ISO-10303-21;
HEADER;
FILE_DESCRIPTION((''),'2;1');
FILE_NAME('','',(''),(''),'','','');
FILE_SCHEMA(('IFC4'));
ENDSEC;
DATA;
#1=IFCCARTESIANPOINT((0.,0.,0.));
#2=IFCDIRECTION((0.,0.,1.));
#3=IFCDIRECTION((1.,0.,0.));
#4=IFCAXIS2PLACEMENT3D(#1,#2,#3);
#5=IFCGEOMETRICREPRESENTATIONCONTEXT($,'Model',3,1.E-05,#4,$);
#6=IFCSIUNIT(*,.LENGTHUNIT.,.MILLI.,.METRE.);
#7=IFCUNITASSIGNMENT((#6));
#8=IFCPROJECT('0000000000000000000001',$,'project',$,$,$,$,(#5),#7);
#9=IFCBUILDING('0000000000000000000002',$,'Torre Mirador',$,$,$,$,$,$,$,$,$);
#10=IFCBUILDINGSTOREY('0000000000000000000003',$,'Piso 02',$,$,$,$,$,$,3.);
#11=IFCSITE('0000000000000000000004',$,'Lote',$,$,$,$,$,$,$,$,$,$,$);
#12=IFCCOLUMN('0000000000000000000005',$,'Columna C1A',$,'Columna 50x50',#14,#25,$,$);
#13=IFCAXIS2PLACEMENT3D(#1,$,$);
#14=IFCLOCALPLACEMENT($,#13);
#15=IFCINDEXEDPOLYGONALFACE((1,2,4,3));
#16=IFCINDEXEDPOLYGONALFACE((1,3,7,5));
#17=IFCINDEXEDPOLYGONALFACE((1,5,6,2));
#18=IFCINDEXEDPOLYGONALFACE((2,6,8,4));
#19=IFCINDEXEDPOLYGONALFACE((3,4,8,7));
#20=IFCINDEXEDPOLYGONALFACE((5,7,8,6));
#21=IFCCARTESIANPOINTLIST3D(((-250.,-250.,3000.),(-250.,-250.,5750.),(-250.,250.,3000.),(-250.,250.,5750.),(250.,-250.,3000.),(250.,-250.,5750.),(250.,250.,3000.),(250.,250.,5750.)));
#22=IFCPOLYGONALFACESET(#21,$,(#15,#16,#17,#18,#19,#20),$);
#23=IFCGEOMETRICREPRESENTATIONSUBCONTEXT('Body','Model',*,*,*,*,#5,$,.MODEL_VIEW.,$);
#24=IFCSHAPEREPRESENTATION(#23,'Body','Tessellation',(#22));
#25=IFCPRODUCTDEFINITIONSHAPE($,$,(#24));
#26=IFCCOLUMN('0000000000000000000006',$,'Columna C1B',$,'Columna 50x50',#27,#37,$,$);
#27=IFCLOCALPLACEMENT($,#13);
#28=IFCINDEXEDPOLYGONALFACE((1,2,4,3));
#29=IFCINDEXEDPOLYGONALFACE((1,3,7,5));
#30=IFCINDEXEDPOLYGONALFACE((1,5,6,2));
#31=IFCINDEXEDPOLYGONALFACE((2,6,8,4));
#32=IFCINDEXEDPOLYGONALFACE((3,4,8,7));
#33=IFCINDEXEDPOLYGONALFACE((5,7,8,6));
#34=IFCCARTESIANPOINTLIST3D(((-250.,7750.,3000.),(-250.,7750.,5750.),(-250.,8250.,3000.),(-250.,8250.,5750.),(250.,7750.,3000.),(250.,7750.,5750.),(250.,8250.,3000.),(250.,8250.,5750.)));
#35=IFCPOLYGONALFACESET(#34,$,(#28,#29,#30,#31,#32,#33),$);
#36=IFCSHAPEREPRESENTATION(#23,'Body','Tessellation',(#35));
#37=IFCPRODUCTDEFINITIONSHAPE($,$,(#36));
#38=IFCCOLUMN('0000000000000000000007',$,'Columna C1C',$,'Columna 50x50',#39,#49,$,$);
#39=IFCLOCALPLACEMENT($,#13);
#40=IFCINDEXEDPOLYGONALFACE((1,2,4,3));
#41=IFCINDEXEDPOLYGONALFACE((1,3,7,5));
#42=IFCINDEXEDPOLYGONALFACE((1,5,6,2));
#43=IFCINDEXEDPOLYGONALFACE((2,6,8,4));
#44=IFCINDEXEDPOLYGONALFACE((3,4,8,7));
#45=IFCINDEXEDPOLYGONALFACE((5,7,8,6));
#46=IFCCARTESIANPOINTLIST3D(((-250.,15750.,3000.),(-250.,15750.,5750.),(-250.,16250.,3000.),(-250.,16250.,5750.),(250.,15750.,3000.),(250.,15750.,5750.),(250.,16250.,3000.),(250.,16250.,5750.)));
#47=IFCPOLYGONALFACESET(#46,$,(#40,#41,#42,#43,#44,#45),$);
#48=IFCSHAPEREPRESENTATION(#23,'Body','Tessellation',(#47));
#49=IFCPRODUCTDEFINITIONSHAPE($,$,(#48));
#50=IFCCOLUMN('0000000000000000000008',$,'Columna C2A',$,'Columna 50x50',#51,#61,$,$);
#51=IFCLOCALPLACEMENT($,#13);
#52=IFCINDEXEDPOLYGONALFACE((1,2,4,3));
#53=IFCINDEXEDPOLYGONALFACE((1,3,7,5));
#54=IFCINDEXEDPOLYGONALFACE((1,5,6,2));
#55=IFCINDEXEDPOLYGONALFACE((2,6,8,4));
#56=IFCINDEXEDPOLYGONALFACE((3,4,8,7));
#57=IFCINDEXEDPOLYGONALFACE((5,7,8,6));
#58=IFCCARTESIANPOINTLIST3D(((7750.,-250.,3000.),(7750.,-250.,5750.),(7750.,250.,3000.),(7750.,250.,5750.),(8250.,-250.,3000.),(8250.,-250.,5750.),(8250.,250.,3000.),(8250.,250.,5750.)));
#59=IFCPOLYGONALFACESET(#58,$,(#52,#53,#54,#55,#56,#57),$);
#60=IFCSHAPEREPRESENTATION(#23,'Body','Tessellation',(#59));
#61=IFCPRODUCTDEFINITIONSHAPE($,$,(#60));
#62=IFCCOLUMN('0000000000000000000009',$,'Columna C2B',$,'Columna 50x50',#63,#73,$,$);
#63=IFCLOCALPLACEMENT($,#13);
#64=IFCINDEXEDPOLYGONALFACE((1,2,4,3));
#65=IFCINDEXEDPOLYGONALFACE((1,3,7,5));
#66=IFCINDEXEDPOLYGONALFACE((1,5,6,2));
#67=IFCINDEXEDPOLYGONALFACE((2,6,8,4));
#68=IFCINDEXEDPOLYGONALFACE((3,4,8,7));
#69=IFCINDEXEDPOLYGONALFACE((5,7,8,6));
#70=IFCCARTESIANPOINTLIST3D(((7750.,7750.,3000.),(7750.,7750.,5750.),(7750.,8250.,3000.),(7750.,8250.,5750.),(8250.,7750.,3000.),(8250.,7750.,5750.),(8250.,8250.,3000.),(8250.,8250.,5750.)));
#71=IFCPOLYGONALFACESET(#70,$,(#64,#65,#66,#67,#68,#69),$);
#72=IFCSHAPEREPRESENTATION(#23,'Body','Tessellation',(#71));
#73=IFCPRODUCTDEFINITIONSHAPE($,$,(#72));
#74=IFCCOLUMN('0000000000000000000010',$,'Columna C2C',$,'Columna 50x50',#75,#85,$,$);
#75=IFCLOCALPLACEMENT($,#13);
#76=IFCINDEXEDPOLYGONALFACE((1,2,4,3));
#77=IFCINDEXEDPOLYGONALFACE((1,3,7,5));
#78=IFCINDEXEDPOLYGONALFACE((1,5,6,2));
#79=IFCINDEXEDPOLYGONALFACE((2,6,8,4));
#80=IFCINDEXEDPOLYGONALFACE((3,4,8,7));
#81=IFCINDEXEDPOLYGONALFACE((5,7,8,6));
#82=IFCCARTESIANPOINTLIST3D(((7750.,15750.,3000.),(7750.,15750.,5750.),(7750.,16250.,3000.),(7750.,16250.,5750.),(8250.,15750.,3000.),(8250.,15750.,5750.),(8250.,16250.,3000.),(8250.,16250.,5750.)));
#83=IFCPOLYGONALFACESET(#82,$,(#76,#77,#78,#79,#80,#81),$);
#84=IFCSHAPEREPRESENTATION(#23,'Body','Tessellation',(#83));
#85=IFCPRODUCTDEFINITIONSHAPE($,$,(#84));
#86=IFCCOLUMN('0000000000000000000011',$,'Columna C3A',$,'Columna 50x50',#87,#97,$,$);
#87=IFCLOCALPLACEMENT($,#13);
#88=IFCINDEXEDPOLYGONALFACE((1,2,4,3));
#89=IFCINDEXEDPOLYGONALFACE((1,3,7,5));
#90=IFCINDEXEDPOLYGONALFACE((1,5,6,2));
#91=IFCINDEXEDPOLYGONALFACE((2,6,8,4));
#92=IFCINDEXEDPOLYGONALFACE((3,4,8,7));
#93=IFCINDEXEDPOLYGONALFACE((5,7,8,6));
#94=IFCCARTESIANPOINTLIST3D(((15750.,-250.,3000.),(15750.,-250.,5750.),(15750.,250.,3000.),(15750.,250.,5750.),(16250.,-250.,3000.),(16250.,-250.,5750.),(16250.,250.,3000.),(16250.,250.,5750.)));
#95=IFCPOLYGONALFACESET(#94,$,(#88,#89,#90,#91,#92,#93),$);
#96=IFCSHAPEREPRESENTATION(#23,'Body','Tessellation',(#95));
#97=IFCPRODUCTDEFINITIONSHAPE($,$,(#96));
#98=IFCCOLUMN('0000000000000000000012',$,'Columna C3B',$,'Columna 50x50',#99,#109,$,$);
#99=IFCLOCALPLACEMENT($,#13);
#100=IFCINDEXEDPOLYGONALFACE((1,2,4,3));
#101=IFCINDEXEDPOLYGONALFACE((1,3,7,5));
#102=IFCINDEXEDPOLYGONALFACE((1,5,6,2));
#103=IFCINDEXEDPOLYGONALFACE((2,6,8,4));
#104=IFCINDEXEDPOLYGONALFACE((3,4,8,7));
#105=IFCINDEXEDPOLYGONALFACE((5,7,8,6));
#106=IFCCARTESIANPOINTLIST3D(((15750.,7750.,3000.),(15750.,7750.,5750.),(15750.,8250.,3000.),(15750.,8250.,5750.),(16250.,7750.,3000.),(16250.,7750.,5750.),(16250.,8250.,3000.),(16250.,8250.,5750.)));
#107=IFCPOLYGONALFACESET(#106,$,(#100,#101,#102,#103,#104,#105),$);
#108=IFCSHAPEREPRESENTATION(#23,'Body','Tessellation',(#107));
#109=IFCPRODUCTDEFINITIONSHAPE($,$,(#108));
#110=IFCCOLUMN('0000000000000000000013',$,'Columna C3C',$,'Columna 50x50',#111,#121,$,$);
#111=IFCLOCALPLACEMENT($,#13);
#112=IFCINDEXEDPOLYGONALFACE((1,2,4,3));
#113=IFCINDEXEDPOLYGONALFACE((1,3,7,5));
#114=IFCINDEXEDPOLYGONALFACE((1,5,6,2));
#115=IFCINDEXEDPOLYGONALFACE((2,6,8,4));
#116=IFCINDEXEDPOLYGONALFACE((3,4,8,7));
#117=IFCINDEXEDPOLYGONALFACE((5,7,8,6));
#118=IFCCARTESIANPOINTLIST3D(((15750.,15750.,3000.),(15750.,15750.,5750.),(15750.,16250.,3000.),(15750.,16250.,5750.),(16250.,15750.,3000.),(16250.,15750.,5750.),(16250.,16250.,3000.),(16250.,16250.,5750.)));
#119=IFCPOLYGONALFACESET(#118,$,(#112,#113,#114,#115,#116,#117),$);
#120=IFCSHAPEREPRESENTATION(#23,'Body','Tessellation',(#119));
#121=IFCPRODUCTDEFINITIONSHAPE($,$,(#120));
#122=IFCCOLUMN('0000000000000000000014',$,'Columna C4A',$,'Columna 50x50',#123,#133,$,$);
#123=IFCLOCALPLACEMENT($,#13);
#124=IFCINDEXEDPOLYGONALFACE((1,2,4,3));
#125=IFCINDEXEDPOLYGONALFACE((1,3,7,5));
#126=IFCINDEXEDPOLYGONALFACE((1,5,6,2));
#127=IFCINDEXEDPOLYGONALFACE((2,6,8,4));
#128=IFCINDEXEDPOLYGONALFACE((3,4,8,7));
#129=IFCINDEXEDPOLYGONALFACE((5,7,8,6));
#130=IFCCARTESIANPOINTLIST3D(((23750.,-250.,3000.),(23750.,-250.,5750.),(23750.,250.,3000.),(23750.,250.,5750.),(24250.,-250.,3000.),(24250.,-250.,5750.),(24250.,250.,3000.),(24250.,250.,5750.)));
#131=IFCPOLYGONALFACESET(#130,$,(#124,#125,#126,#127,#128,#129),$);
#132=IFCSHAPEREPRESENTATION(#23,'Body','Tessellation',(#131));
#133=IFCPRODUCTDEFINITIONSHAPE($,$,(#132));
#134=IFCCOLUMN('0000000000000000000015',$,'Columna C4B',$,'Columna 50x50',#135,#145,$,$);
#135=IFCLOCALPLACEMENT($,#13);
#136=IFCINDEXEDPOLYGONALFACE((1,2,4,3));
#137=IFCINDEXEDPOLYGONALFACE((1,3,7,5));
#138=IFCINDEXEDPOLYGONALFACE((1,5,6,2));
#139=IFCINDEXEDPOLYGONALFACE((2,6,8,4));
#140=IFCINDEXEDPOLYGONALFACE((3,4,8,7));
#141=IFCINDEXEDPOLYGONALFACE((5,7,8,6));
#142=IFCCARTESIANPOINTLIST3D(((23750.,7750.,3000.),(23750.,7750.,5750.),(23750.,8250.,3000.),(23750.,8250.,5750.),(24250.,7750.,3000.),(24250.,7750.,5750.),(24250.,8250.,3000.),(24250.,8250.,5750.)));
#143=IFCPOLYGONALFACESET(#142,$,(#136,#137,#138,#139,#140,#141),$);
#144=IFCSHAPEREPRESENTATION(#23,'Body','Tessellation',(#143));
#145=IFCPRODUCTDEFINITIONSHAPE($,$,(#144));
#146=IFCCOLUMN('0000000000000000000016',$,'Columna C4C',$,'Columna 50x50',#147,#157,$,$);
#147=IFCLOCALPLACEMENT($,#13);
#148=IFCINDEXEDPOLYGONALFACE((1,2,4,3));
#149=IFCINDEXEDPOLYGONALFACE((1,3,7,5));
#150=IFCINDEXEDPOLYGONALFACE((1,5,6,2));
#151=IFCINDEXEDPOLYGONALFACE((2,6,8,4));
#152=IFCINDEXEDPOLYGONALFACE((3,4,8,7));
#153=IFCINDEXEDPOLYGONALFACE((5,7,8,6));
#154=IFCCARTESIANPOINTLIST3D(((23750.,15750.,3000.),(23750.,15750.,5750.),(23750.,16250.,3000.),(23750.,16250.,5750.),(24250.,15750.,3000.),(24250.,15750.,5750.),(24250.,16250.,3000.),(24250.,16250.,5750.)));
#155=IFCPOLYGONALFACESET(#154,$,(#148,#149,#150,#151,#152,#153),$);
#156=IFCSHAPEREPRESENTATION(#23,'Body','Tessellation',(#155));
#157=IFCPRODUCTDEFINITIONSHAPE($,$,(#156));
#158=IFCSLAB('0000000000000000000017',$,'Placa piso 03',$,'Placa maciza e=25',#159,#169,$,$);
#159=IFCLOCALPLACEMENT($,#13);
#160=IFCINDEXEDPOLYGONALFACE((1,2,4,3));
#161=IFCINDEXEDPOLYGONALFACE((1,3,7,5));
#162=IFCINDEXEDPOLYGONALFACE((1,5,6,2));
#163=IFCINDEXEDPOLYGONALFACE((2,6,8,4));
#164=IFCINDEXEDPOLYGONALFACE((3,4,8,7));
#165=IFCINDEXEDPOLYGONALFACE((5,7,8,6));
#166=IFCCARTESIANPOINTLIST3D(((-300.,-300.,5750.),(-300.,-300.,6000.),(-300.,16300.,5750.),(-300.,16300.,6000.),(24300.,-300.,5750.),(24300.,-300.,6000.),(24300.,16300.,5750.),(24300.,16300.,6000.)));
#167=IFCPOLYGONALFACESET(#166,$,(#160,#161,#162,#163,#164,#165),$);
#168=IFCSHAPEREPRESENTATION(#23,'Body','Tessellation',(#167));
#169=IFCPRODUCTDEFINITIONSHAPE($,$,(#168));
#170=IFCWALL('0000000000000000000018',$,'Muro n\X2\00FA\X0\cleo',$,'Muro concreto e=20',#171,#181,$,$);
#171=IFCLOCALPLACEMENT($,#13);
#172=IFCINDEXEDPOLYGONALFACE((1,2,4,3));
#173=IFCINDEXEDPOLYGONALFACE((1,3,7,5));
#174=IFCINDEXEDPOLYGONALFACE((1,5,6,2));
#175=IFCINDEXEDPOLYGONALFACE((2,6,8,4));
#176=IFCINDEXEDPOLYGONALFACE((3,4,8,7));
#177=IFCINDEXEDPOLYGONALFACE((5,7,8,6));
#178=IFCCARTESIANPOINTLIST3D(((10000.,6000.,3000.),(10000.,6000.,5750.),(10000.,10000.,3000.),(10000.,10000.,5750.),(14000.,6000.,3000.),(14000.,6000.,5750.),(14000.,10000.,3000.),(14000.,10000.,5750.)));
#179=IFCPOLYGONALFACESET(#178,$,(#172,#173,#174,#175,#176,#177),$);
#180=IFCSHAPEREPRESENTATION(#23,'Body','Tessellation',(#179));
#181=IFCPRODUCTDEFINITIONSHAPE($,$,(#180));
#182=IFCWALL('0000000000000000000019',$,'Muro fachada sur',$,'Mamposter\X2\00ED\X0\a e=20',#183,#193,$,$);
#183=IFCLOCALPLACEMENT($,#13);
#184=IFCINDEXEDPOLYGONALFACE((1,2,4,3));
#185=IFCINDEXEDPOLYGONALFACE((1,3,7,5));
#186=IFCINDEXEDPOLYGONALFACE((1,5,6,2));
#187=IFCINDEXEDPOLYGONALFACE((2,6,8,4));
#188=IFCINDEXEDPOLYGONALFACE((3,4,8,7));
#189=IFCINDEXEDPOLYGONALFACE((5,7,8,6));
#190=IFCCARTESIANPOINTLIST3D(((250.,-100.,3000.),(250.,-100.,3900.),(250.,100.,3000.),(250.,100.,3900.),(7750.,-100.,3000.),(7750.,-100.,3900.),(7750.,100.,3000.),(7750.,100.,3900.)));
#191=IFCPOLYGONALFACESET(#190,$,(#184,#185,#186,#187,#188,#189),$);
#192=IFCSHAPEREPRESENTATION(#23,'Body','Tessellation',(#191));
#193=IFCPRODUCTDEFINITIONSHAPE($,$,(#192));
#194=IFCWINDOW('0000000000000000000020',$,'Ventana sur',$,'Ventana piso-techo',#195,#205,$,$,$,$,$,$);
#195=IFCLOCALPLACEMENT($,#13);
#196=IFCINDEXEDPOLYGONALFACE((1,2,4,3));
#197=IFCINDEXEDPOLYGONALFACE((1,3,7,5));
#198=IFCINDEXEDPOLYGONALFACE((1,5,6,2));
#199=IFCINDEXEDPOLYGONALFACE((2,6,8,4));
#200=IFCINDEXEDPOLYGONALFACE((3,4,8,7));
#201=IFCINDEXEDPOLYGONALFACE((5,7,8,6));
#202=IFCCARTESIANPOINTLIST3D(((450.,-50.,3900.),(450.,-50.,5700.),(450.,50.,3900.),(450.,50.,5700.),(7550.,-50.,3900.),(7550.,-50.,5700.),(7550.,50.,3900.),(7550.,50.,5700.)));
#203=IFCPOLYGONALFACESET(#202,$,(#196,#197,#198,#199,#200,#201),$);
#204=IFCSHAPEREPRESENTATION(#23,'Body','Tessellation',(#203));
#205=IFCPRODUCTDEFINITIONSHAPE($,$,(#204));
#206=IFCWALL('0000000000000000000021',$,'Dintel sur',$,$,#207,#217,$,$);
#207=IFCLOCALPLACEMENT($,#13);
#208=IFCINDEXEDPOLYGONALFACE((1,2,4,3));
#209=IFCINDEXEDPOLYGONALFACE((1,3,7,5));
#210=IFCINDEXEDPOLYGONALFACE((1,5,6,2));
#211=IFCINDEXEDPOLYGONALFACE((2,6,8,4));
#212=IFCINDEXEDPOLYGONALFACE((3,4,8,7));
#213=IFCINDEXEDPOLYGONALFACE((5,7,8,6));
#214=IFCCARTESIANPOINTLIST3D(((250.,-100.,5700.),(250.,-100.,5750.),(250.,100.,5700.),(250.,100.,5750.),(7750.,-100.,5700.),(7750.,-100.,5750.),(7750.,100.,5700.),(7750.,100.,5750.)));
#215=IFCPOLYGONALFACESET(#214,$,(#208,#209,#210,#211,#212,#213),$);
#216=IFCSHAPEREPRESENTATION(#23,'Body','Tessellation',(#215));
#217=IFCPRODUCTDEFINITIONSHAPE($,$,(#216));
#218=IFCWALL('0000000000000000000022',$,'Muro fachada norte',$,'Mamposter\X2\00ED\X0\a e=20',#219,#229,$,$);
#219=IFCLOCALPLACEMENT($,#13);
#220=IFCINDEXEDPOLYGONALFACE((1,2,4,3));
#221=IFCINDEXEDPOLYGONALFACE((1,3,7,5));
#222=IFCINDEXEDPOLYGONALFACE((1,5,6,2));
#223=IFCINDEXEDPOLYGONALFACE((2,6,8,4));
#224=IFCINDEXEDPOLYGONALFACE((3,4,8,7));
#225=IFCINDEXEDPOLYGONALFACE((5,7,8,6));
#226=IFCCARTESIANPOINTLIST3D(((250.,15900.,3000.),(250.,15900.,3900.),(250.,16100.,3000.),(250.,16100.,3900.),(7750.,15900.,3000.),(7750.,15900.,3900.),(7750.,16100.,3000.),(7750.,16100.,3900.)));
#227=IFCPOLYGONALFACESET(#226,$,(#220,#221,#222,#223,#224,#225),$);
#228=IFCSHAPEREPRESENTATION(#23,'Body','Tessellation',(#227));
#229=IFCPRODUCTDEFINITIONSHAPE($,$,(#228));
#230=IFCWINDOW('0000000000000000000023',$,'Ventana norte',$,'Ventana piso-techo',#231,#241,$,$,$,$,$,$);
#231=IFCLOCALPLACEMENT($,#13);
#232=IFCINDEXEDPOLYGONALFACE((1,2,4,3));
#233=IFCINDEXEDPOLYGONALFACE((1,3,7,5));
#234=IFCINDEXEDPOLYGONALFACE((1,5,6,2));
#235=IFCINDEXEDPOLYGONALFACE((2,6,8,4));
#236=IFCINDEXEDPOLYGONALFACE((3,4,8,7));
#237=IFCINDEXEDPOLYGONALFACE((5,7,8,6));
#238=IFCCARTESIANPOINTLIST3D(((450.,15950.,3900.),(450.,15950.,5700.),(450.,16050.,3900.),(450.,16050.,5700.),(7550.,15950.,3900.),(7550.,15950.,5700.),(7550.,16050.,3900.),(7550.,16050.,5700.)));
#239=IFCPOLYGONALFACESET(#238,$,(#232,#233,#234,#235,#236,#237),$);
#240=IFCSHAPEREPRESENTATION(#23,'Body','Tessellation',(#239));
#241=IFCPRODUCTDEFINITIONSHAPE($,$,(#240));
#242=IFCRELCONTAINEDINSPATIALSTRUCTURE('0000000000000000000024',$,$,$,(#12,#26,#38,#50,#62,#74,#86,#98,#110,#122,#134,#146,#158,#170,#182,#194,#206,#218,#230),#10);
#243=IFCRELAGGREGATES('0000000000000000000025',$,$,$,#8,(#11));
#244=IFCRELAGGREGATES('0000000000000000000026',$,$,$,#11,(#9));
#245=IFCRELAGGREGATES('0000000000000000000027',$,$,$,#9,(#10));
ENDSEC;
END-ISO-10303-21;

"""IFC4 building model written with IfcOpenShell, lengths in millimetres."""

from ifc_helpers import new_model, si_unit, frame, origin_with_axes, place, context, subcontext, project, spatial, indexed_curve, outline, extrude, element, save


model = new_model("IFC4")

# Units and contexts
model_context = context("Model", 3, precision=1e-05, world=origin_with_axes())
body_context = subcontext(model_context, "Body", "Model", "MODEL_VIEW")
ifc_project = project(units=[si_unit("LENGTHUNIT", "METRE", prefix="MILLI")], contexts=[model_context])

# Site, building, storey
site = spatial("IfcSite", under=ifc_project, Name="Lote")
building = spatial("IfcBuilding", under=site, Name="Torre Mirador")
storey = spatial("IfcBuildingStorey", under=building, Name="Piso 02", Elevation=3.0)

# Columns
for number, where, z_axis, x_axis, name in (
    (1, (-250.0, -250.0, 3000.0), (0.0, 0.0, 1.0), (1.0, 0.0, 0.0), "Columna C1A"),
    (2, (-250.0, 7750.0, 3000.0), (0.0, 0.0, 1.0), (1.0, 0.0, 0.0), "Columna C1B"),
    (3, (-250.0, 15750.0, 3000.0), (0.0, 0.0, 1.0), (1.0, 0.0, 0.0), "Columna C1C"),
    (4, (7750.0, -250.0, 3000.0), (0.0, 0.0, 1.0), (1.0, 0.0, 0.0), "Columna C2A"),
    (5, (7750.0, 7750.0, 3000.0), (0.0, 0.0, 1.0), (1.0, 0.0, 0.0), "Columna C2B"),
    (6, (7750.0, 15750.0, 3000.0), (0.0, 0.0, 1.0), (1.0, 0.0, 0.0), "Columna C2C"),
    (7, (15750.0, -250.0, 3000.0), (0.0, 0.0, 1.0), (1.0, 0.0, 0.0), "Columna C3A"),
    (8, (15750.0, 7750.0, 3000.0), (0.0, 0.0, 1.0), (1.0, 0.0, 0.0), "Columna C3B"),
    (9, (15750.0, 15750.0, 3000.0), (0.0, 0.0, 1.0), (1.0, 0.0, 0.0), "Columna C3C"),
    (10, (23750.0, -250.0, 3000.0), (0.0, 0.0, 1.0), (1.0, 0.0, 0.0), "Columna C4A"),
    (11, (23750.0, 7750.0, 3000.0), (0.0, 0.0, 1.0), (1.0, 0.0, 0.0), "Columna C4B"),
    (12, (23750.0, 15750.0, 3000.0), (0.0, 0.0, 1.0), (1.0, 0.0, 0.0), "Columna C4C"),
):
    element("IfcColumn", number, at=place(None, frame(where, z_axis=z_axis, x_axis=x_axis)), inside=storey, Name=name, ObjectType="Columna 50x50", context=body_context, shape_type="SweptSolid", body=[
        extrude(outline(indexed_curve([(0.0, 0.0), (0.0, 500.0), (500.0, 500.0), (500.0, 0.0), (0.0, 0.0)], self_intersect=False)), origin_with_axes(), (0.0, 0.0, 1.0), 2750.0),
    ])

# Slab
slab_placement = place(None, frame((-300.0, -300.0, 5750.0), z_axis=(0.0, 0.0, 1.0), x_axis=(1.0, 0.0, 0.0)))
element("IfcSlab", 13, at=slab_placement, inside=storey, Name="Placa piso 03", ObjectType="Placa maciza e=25", context=body_context, shape_type="SweptSolid", body=[
    extrude(outline(indexed_curve([(0.0, 0.0), (0.0, 16600.0), (24600.0, 16600.0), (24600.0, 0.0), (0.0, 0.0)], self_intersect=False)), origin_with_axes(), (0.0, 0.0, 1.0), 250.0),
])

# Walls
wall_1_placement = place(None, frame((10000.0, 6000.0, 3000.0), z_axis=(0.0, 0.0, 1.0), x_axis=(1.0, 0.0, 0.0)))
element("IfcWall", 14, at=wall_1_placement, inside=storey, Name="Muro núcleo", ObjectType="Muro concreto e=20", context=body_context, shape_type="SweptSolid", body=[
    extrude(outline(indexed_curve([(0.0, 0.0), (0.0, 4000.0), (4000.0, 4000.0), (4000.0, 0.0), (0.0, 0.0)], self_intersect=False)), origin_with_axes(), (0.0, 0.0, 1.0), 2750.0),
])
wall_2_placement = place(None, frame((250.0, -100.0, 3000.0), z_axis=(0.0, 0.0, 1.0), x_axis=(1.0, 0.0, 0.0)))
element("IfcWall", 15, at=wall_2_placement, inside=storey, Name="Muro fachada sur", ObjectType="Mampostería e=20", context=body_context, shape_type="SweptSolid", body=[
    extrude(outline(indexed_curve([(0.0, 0.0), (0.0, 200.0), (7500.0, 200.0), (7500.0, 0.0), (0.0, 0.0)], self_intersect=False)), origin_with_axes(), (0.0, 0.0, 1.0), 900.0),
])

# Window
window_1_placement = place(None, frame((450.0, -50.0, 3900.0), z_axis=(0.0, 0.0, 1.0), x_axis=(1.0, 0.0, 0.0)))
element("IfcWindow", 16, at=window_1_placement, inside=storey, Name="Ventana sur", ObjectType="Ventana piso-techo", context=body_context, shape_type="SweptSolid", body=[
    extrude(outline(indexed_curve([(0.0, 0.0), (0.0, 100.0), (7100.0, 100.0), (7100.0, 0.0), (0.0, 0.0)], self_intersect=False)), origin_with_axes(), (0.0, 0.0, 1.0), 1800.0),
])

# Walls
wall_3_placement = place(None, frame((250.0, -100.0, 5700.0), z_axis=(0.0, 0.0, 1.0), x_axis=(1.0, 0.0, 0.0)))
element("IfcWall", 17, at=wall_3_placement, inside=storey, Name="Dintel sur", context=body_context, shape_type="SweptSolid", body=[
    extrude(outline(indexed_curve([(0.0, 0.0), (0.0, 200.0), (7500.0, 200.0), (7500.0, 0.0), (0.0, 0.0)], self_intersect=False)), origin_with_axes(), (0.0, 0.0, 1.0), 50.0),
])
wall_4_placement = place(None, frame((250.0, 15900.0, 3000.0), z_axis=(0.0, 0.0, 1.0), x_axis=(1.0, 0.0, 0.0)))
element("IfcWall", 18, at=wall_4_placement, inside=storey, Name="Muro fachada norte", ObjectType="Mampostería e=20", context=body_context, shape_type="SweptSolid", body=[
    extrude(outline(indexed_curve([(0.0, 0.0), (0.0, 200.0), (7500.0, 200.0), (7500.0, 0.0), (0.0, 0.0)], self_intersect=False)), origin_with_axes(), (0.0, 0.0, 1.0), 900.0),
])

# Window
window_2_placement = place(None, frame((450.0, 15950.0, 3900.0), z_axis=(0.0, 0.0, 1.0), x_axis=(1.0, 0.0, 0.0)))
element("IfcWindow", 19, at=window_2_placement, inside=storey, Name="Ventana norte", ObjectType="Ventana piso-techo", context=body_context, shape_type="SweptSolid", body=[
    extrude(outline(indexed_curve([(0.0, 0.0), (0.0, 100.0), (7100.0, 100.0), (7100.0, 0.0), (0.0, 0.0)], self_intersect=False)), origin_with_axes(), (0.0, 0.0, 1.0), 1800.0),
])

save(model, "model.ifc")
